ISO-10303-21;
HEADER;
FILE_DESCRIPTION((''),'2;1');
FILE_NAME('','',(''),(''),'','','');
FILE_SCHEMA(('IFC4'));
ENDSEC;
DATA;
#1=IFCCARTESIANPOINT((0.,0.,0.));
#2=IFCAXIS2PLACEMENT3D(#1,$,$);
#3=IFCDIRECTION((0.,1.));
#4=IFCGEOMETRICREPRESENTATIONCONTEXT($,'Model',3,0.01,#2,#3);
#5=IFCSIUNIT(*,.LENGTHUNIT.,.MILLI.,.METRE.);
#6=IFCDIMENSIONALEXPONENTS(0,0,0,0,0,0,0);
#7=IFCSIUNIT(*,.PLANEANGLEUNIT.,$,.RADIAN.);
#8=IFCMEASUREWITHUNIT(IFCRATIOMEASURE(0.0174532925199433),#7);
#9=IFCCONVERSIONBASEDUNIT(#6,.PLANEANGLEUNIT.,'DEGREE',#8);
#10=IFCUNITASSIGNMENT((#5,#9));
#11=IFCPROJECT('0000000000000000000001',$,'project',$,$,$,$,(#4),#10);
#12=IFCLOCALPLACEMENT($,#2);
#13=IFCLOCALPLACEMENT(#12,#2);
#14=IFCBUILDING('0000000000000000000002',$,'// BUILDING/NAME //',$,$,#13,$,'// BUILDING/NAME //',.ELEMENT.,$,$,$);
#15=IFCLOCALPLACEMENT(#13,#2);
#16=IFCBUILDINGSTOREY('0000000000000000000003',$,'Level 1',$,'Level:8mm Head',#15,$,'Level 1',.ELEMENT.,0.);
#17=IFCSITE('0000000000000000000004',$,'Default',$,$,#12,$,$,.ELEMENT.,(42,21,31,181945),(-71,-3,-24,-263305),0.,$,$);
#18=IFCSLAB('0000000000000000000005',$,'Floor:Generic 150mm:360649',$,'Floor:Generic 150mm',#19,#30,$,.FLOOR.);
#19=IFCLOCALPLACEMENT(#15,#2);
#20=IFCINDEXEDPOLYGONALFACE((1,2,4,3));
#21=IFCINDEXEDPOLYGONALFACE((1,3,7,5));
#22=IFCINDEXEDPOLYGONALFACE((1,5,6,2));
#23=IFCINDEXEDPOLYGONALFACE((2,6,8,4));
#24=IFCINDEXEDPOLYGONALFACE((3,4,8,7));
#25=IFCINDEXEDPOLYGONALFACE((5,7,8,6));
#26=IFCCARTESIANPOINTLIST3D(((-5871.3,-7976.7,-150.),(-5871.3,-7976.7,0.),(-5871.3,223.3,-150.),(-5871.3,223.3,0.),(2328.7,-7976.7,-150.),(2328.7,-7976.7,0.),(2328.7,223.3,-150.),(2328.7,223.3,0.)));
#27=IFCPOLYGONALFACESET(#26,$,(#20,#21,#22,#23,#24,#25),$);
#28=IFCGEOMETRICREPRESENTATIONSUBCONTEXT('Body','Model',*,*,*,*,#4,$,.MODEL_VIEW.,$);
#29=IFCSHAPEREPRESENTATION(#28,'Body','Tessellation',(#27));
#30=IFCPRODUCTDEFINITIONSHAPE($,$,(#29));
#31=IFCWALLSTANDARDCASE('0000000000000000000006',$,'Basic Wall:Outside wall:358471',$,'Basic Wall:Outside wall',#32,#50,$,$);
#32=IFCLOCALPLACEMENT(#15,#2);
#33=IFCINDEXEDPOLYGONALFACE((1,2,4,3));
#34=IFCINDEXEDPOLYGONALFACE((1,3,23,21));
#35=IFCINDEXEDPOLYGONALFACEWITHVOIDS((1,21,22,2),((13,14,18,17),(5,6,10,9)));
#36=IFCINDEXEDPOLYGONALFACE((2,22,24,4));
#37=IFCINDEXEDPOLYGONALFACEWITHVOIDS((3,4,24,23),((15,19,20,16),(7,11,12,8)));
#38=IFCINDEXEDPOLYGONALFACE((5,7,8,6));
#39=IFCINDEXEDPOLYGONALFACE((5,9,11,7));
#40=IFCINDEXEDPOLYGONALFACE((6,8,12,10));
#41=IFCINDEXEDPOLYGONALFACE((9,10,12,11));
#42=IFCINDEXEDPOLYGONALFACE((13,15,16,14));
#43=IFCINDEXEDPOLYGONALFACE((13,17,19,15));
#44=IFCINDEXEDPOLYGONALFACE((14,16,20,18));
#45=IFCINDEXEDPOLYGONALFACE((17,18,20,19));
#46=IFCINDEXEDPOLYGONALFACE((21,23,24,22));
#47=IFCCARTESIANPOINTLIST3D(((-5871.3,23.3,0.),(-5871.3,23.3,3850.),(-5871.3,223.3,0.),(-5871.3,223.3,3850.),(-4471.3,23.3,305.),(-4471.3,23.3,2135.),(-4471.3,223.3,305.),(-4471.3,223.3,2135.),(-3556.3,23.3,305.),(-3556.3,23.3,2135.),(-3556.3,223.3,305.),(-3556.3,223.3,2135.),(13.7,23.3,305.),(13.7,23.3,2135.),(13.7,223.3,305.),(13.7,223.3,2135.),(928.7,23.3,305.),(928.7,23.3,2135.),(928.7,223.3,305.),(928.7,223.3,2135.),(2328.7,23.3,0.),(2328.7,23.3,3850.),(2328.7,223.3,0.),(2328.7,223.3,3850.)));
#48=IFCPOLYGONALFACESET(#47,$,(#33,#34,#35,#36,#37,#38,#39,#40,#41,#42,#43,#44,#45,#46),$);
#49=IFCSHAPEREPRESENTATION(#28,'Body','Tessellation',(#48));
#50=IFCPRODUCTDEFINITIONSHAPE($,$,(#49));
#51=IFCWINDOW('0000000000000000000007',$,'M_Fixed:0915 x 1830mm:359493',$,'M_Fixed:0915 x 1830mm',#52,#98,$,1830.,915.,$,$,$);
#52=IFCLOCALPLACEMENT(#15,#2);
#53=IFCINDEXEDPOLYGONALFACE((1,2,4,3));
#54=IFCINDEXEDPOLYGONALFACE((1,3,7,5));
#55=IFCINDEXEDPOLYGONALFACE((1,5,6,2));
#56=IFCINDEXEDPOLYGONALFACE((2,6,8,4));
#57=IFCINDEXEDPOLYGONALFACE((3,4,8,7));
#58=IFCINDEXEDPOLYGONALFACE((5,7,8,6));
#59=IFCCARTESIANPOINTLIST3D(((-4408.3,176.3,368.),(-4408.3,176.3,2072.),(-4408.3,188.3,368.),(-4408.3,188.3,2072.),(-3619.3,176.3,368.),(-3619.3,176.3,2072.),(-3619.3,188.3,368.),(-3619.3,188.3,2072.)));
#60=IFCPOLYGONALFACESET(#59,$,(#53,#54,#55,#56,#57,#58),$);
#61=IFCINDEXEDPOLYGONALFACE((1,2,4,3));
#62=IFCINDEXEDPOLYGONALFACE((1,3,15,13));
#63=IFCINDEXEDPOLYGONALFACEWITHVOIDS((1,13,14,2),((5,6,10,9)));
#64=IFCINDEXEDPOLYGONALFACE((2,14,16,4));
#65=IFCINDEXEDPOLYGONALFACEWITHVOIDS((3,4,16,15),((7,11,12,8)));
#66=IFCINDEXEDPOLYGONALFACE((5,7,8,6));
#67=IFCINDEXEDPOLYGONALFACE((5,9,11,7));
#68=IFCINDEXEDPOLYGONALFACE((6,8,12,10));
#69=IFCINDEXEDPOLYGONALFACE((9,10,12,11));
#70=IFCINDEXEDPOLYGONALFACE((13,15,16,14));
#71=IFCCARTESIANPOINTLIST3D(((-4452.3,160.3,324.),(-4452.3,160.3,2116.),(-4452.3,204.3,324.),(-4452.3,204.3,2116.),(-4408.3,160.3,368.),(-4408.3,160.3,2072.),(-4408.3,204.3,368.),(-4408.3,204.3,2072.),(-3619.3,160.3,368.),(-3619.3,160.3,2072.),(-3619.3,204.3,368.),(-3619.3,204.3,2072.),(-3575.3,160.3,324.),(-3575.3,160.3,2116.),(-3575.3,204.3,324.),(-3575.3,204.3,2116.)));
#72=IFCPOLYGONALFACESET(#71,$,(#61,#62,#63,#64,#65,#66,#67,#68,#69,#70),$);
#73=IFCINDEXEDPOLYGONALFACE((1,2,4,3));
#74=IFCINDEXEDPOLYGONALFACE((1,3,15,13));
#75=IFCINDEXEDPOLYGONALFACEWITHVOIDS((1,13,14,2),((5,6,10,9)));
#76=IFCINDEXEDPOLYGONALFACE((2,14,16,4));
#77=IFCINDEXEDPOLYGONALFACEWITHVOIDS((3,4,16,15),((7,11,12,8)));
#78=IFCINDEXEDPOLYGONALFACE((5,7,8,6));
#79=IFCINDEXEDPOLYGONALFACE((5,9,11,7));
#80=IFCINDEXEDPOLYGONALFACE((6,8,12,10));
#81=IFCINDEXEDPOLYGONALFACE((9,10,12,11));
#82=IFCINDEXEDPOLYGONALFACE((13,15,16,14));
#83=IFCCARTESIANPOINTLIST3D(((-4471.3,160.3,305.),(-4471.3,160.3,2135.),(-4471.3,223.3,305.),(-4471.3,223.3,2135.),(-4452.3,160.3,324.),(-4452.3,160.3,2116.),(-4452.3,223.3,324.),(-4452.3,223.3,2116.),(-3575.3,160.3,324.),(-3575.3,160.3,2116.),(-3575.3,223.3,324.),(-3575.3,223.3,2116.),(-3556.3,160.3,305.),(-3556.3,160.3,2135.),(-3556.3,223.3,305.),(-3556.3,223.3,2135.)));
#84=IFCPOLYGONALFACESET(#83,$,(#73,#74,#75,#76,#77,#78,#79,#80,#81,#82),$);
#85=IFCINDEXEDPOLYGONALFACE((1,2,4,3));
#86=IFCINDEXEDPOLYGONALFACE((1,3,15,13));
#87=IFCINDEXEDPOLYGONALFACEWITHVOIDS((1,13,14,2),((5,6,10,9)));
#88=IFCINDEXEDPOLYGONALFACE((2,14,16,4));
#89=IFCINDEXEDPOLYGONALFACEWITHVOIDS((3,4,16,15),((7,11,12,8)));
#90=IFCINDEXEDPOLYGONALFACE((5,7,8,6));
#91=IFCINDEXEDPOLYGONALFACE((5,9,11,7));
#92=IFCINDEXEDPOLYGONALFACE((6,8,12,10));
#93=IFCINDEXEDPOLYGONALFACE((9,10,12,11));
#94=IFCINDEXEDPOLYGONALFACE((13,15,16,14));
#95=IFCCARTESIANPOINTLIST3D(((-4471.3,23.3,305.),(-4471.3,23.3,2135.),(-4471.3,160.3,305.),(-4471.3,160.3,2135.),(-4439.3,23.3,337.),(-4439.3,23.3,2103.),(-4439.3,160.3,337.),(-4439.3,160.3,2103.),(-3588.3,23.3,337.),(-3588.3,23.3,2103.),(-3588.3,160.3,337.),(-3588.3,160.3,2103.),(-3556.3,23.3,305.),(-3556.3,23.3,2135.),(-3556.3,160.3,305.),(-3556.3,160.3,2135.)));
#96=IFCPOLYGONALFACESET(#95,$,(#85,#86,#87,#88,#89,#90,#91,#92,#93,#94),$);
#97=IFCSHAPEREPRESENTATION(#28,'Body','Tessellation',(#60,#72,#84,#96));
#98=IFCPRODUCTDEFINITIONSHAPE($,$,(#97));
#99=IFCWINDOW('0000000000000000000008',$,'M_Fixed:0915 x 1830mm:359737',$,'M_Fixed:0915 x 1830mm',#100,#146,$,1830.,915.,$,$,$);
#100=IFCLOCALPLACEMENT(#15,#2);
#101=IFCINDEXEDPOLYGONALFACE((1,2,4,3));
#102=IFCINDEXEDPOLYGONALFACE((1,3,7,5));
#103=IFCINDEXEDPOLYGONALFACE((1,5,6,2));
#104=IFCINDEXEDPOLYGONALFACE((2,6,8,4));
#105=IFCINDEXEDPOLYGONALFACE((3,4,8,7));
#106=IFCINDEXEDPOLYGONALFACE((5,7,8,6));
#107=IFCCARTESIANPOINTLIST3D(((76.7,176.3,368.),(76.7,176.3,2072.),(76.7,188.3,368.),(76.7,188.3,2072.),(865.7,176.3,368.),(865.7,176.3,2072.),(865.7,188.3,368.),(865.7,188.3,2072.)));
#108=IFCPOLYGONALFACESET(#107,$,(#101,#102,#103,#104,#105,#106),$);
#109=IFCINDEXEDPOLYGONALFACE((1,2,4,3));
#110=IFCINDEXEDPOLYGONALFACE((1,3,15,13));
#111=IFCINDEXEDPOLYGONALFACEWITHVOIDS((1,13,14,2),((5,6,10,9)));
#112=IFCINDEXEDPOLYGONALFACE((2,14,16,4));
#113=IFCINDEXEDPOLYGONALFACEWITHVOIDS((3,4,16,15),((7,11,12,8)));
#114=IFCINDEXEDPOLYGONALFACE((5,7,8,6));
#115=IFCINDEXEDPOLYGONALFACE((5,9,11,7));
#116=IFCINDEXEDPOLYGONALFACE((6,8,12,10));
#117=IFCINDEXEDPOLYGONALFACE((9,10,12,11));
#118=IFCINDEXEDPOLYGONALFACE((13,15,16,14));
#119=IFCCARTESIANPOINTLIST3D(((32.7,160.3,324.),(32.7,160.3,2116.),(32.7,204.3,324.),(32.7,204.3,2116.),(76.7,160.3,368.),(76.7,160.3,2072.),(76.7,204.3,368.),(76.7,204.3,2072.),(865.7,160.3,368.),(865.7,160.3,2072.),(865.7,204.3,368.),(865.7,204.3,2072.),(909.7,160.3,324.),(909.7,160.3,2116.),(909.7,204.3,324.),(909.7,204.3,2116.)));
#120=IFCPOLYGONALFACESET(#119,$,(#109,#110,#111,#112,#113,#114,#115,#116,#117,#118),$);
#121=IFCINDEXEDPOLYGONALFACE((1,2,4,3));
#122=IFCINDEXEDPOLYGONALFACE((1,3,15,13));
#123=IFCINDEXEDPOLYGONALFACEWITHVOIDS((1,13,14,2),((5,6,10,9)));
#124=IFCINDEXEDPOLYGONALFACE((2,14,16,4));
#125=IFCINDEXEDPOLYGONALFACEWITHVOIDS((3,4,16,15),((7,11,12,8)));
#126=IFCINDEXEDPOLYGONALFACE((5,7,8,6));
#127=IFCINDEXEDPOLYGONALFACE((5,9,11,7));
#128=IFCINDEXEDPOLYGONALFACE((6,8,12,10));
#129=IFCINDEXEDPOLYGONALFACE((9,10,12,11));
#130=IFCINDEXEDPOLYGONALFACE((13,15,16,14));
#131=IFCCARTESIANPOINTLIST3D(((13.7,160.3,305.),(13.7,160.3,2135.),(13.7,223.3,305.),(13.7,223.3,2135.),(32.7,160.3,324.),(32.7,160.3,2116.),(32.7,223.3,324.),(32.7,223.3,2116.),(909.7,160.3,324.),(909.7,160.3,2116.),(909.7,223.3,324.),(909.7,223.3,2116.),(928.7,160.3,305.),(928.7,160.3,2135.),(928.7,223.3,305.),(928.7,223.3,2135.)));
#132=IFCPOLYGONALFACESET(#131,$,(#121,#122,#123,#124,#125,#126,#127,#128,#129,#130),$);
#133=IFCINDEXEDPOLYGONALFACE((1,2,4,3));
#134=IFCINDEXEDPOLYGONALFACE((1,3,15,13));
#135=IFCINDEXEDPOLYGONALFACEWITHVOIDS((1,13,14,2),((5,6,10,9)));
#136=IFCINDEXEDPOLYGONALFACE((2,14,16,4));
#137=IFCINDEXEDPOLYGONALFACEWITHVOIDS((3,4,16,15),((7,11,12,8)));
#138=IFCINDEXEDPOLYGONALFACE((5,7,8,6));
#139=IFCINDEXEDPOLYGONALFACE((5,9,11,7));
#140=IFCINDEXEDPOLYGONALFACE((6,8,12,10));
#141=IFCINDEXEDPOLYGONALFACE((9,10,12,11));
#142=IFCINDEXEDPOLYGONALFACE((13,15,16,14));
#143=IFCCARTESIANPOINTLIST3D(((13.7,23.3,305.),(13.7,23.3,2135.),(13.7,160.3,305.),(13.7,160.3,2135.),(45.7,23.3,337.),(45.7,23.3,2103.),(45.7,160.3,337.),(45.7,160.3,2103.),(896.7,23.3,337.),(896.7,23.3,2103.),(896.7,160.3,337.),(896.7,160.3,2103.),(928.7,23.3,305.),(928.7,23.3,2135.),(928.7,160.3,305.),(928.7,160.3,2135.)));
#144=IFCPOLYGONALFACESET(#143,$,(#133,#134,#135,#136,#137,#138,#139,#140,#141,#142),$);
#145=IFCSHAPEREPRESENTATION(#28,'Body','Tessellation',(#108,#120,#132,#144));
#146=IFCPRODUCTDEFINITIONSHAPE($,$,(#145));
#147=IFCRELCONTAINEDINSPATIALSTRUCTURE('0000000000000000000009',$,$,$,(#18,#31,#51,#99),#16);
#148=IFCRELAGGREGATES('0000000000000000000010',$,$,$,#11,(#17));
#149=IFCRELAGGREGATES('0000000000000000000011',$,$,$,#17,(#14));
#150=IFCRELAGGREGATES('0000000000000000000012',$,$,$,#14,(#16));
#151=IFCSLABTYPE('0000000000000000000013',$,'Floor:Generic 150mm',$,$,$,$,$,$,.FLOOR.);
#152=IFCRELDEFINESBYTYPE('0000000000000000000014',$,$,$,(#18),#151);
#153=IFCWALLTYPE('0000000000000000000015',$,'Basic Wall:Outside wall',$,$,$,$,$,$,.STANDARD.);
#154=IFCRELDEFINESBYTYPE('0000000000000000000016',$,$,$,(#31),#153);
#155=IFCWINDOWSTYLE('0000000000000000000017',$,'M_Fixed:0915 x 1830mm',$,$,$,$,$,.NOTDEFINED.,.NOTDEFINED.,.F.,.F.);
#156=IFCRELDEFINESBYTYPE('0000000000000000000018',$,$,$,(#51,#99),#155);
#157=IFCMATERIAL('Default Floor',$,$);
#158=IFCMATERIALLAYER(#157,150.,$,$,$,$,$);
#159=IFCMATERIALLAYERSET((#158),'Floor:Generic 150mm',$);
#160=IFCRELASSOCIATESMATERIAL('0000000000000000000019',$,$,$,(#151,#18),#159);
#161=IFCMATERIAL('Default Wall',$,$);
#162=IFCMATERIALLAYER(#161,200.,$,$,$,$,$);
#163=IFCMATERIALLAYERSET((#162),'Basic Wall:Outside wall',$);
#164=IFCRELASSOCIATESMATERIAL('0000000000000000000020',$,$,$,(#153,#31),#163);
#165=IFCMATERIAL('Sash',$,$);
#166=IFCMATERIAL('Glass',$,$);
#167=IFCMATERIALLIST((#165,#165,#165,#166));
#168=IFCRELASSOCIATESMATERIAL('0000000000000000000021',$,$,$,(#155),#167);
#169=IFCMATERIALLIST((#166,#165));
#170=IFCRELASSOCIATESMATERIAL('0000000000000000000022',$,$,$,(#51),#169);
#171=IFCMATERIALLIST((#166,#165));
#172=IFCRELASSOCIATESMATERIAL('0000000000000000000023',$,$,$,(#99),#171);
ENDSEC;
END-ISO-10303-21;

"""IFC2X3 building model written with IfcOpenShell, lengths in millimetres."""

from ifc_helpers import new_model, entity, si_unit, converted_unit, direction, frame, frame_2d, origin, place, context, subcontext, project, spatial, polyline, rectangle, outline, extrude, clip, halfspace, bounded_halfspace, source, transform, mapped, material, material_list, layer, layer_set, layer_usage, type_object, type_shapes, element, fill, save


model = new_model("IFC2X3")

# Units and contexts
model_context = context("Model", 3, precision=0.01, world=origin(), true_north=direction((0.0, 1.0)))
body_context = subcontext(model_context, "Body", "Model", "MODEL_VIEW")
ifc_project = project(units=[si_unit("LENGTHUNIT", "METRE", prefix="MILLI"), converted_unit("PLANEANGLEUNIT", "DEGREE", entity("IfcRatioMeasure", 0.0174532925199433), si_unit("PLANEANGLEUNIT", "RADIAN"), dimensions=[0, 0, 0, 0, 0, 0, 0])], contexts=[model_context])

# Site, building, storey
site_placement = place(None, origin())
site = spatial("IfcSite", under=ifc_project, at=site_placement, Name="Default", CompositionType="ELEMENT", RefLatitude=(42, 21, 31, 181945), RefLongitude=(-71, -3, -24, -263305), RefElevation=0.0)
building_placement = place(site_placement, origin())
building = spatial("IfcBuilding", under=site, at=building_placement, Name="// BUILDING/NAME //", LongName="// BUILDING/NAME //", CompositionType="ELEMENT")
storey_placement = place(building_placement, origin())
storey = spatial("IfcBuildingStorey", under=building, at=storey_placement, Name="Level 1", ObjectType="Level:8mm Head", LongName="Level 1", CompositionType="ELEMENT", Elevation=0.0)

# Slab
ifc_material_1 = material(Name="Default Floor")
ifc_layer_1 = layer(ifc_material_1, 150.0)
ifc_layer_set_1 = layer_set([ifc_layer_1], Name="Floor:Generic 150mm")
ifc_layer_usage_1 = layer_usage(ifc_layer_set_1, "AXIS3", "POSITIVE", 0.0)
slab_type = type_object("IfcSlabType", Name="Floor:Generic 150mm", PredefinedType="FLOOR", material=ifc_layer_set_1)
slab_placement = place(storey_placement, origin())
element("IfcSlab", 1, at=slab_placement, inside=storey, type_object=slab_type, material=ifc_layer_usage_1, Name="Floor:Generic 150mm:360649", ObjectType="Floor:Generic 150mm", PredefinedType="FLOOR", context=body_context, shape_type="SweptSolid", body=[
    extrude(rectangle(XDim=8200.0, YDim=8200.0, at=frame_2d((0.0, 0.0), x_axis=(1.0, 0.0))), frame((-1771.3, -3876.7, 0.0), z_axis=(0.0, 0.0, -1.0), x_axis=(0.0, 1.0, 0.0)), (0.0, 0.0, 1.0), 150.0),
])

# Wall, openings, windows
ifc_material_2 = material(Name="Default Wall")
ifc_layer_2 = layer(ifc_material_2, 200.0)
ifc_layer_set_2 = layer_set([ifc_layer_2], Name="Basic Wall:Outside wall")
ifc_layer_usage_2 = layer_usage(ifc_layer_set_2, "AXIS2", "NEGATIVE", 100.0)
wall_type_1 = type_object("IfcWallType", Name="Basic Wall:Outside wall", PredefinedType="STANDARD", material=ifc_layer_set_2)
wall_1_placement = place(storey_placement, frame((-5871.3, 123.3, 0.0)))
wall_1 = element("IfcWallStandardCase", 2, at=wall_1_placement, inside=storey, type_object=wall_type_1, material=ifc_layer_usage_2, Name="Basic Wall:Outside wall:358471", ObjectType="Basic Wall:Outside wall", context=body_context, shape_type="Clipping", body=[
    clip(clip(extrude(rectangle(XDim=8200.0, YDim=200.0, at=frame_2d((4100.0, 0.0), x_axis=(-1.0, 0.0))), origin(), (0.0, 0.0, 1.0), 3850.0), bounded_halfspace(frame((0.0, -100.0, 3850.0), z_axis=(0.0, 0.0, -1.0), x_axis=(0.0, -1.0, 0.0)), True, frame((0.0, -100.0, 3850.0), z_axis=(0.0, 0.0, -1.0), x_axis=(0.0, -1.0, 0.0)), polyline([(0.0, 0.0), (-200.0, 0.0), (-200.0, -8200.0), (0.0, -8200.0), (0.0, -8000.0), (0.0, -200.0), (0.0, 0.0)]))), halfspace(origin(), True)),
])
opening_1_placement = place(wall_1_placement, frame((1400.0, -100.0, 305.0)))
opening_1 = element("IfcOpeningElement", 3, at=opening_1_placement, cuts=wall_1, ObjectType="Opening", context=body_context, shape_type="SweptSolid", body=[
    extrude(rectangle(XDim=1830.0, YDim=915.0, at=frame_2d((915.0, 457.5), x_axis=(1.0, 0.0))), frame((0.0, 0.0, 0.0), z_axis=(0.0, 1.0, 0.0), x_axis=(0.0, 0.0, 1.0)), (0.0, 0.0, 1.0), 200.0),
])
opening_2_placement = place(wall_1_placement, frame((5885.0, -100.0, 305.0)))
opening_2 = element("IfcOpeningElement", 4, at=opening_2_placement, cuts=wall_1, ObjectType="Opening", context=body_context, shape_type="SweptSolid", body=[
    extrude(rectangle(XDim=1830.0, YDim=915.0, at=frame_2d((915.0, 457.5), x_axis=(1.0, 0.0))), frame((0.0, 0.0, 0.0), z_axis=(0.0, 1.0, 0.0), x_axis=(0.0, 0.0, 1.0)), (0.0, 0.0, 1.0), 200.0),
])
ifc_material_3 = material(Name="Glass")
ifc_material_4 = material(Name="Sash")
ifc_material_list_1 = material_list([ifc_material_3, ifc_material_4])
ifc_material_list_2 = material_list([ifc_material_4, ifc_material_4, ifc_material_4, ifc_material_3])
window_style = type_object("IfcWindowStyle", Name="M_Fixed:0915 x 1830mm", ConstructionType="NOTDEFINED", OperationType="NOTDEFINED", ParameterTakesPrecedence=False, Sizeable=False, material=ifc_material_list_2)
shared_shape_1 = source(origin(), body_context, "Body", "SweptSolid", [
    extrude(rectangle(XDim=12.0, YDim=789.0, at=frame_2d((0.0, 0.0), x_axis=(1.0, 0.0))), frame((457.5, 159.0, 63.0), z_axis=(0.0, 0.0, 1.0), x_axis=(0.0, -1.0, 0.0)), (0.0, 0.0, 1.0), 1704.0),
    extrude(outline(polyline([(-438.5, -896.0), (438.5, -896.0), (438.5, 896.0), (-438.5, 896.0), (-438.5, -896.0)]), holes=[polyline([(-394.5, -852.0), (-394.5, 852.0), (394.5, 852.0), (394.5, -852.0), (-394.5, -852.0)])]), frame((457.5, 137.0, 915.0), z_axis=(0.0, 1.0, 0.0), x_axis=(1.0, 0.0, 0.0)), (0.0, 0.0, 1.0), 44.0),
    extrude(outline(polyline([(-457.5, -915.0), (457.5, -915.0), (457.5, 915.0), (-457.5, 915.0), (-457.5, -915.0)]), holes=[polyline([(-438.5, -896.0), (-438.5, 896.0), (438.5, 896.0), (438.5, -896.0), (-438.5, -896.0)])]), frame((457.5, 137.0, 915.0), z_axis=(0.0, 1.0, 0.0), x_axis=(1.0, 0.0, 0.0)), (0.0, 0.0, 1.0), 63.0),
    extrude(outline(polyline([(-457.5, -915.0), (457.5, -915.0), (457.5, 915.0), (-457.5, 915.0), (-457.5, -915.0)]), holes=[polyline([(-425.5, -883.0), (-425.5, 883.0), (425.5, 883.0), (425.5, -883.0), (-425.5, -883.0)])]), frame((457.5, 0.0, 915.0), z_axis=(0.0, 1.0, 0.0), x_axis=(1.0, 0.0, 0.0)), (0.0, 0.0, 1.0), 137.0),
])
type_shapes(window_style, [shared_shape_1])
window_1_placement = place(opening_1_placement, origin())
window_1 = element("IfcWindow", 5, at=window_1_placement, inside=storey, type_object=window_style, material=ifc_material_list_1, Name="M_Fixed:0915 x 1830mm:359493", ObjectType="M_Fixed:0915 x 1830mm", OverallHeight=1830.0, OverallWidth=915.0, context=body_context, shape_type="MappedRepresentation", body=[
    mapped(shared_shape_1, transform((0.0, 0.0, 0.0), scale=1.0)),
])
fill(opening_1, window_1)
ifc_material_list_3 = material_list([ifc_material_3, ifc_material_4])
window_2_placement = place(opening_2_placement, origin())
window_2 = element("IfcWindow", 6, at=window_2_placement, inside=storey, type_object=window_style, material=ifc_material_list_3, Name="M_Fixed:0915 x 1830mm:359737", ObjectType="M_Fixed:0915 x 1830mm", OverallHeight=1830.0, OverallWidth=915.0, context=body_context, shape_type="MappedRepresentation", body=[
    mapped(shared_shape_1, transform((0.0, 0.0, 0.0), scale=1.0)),
])
fill(opening_2, window_2)

save(model, "model.ifc")
